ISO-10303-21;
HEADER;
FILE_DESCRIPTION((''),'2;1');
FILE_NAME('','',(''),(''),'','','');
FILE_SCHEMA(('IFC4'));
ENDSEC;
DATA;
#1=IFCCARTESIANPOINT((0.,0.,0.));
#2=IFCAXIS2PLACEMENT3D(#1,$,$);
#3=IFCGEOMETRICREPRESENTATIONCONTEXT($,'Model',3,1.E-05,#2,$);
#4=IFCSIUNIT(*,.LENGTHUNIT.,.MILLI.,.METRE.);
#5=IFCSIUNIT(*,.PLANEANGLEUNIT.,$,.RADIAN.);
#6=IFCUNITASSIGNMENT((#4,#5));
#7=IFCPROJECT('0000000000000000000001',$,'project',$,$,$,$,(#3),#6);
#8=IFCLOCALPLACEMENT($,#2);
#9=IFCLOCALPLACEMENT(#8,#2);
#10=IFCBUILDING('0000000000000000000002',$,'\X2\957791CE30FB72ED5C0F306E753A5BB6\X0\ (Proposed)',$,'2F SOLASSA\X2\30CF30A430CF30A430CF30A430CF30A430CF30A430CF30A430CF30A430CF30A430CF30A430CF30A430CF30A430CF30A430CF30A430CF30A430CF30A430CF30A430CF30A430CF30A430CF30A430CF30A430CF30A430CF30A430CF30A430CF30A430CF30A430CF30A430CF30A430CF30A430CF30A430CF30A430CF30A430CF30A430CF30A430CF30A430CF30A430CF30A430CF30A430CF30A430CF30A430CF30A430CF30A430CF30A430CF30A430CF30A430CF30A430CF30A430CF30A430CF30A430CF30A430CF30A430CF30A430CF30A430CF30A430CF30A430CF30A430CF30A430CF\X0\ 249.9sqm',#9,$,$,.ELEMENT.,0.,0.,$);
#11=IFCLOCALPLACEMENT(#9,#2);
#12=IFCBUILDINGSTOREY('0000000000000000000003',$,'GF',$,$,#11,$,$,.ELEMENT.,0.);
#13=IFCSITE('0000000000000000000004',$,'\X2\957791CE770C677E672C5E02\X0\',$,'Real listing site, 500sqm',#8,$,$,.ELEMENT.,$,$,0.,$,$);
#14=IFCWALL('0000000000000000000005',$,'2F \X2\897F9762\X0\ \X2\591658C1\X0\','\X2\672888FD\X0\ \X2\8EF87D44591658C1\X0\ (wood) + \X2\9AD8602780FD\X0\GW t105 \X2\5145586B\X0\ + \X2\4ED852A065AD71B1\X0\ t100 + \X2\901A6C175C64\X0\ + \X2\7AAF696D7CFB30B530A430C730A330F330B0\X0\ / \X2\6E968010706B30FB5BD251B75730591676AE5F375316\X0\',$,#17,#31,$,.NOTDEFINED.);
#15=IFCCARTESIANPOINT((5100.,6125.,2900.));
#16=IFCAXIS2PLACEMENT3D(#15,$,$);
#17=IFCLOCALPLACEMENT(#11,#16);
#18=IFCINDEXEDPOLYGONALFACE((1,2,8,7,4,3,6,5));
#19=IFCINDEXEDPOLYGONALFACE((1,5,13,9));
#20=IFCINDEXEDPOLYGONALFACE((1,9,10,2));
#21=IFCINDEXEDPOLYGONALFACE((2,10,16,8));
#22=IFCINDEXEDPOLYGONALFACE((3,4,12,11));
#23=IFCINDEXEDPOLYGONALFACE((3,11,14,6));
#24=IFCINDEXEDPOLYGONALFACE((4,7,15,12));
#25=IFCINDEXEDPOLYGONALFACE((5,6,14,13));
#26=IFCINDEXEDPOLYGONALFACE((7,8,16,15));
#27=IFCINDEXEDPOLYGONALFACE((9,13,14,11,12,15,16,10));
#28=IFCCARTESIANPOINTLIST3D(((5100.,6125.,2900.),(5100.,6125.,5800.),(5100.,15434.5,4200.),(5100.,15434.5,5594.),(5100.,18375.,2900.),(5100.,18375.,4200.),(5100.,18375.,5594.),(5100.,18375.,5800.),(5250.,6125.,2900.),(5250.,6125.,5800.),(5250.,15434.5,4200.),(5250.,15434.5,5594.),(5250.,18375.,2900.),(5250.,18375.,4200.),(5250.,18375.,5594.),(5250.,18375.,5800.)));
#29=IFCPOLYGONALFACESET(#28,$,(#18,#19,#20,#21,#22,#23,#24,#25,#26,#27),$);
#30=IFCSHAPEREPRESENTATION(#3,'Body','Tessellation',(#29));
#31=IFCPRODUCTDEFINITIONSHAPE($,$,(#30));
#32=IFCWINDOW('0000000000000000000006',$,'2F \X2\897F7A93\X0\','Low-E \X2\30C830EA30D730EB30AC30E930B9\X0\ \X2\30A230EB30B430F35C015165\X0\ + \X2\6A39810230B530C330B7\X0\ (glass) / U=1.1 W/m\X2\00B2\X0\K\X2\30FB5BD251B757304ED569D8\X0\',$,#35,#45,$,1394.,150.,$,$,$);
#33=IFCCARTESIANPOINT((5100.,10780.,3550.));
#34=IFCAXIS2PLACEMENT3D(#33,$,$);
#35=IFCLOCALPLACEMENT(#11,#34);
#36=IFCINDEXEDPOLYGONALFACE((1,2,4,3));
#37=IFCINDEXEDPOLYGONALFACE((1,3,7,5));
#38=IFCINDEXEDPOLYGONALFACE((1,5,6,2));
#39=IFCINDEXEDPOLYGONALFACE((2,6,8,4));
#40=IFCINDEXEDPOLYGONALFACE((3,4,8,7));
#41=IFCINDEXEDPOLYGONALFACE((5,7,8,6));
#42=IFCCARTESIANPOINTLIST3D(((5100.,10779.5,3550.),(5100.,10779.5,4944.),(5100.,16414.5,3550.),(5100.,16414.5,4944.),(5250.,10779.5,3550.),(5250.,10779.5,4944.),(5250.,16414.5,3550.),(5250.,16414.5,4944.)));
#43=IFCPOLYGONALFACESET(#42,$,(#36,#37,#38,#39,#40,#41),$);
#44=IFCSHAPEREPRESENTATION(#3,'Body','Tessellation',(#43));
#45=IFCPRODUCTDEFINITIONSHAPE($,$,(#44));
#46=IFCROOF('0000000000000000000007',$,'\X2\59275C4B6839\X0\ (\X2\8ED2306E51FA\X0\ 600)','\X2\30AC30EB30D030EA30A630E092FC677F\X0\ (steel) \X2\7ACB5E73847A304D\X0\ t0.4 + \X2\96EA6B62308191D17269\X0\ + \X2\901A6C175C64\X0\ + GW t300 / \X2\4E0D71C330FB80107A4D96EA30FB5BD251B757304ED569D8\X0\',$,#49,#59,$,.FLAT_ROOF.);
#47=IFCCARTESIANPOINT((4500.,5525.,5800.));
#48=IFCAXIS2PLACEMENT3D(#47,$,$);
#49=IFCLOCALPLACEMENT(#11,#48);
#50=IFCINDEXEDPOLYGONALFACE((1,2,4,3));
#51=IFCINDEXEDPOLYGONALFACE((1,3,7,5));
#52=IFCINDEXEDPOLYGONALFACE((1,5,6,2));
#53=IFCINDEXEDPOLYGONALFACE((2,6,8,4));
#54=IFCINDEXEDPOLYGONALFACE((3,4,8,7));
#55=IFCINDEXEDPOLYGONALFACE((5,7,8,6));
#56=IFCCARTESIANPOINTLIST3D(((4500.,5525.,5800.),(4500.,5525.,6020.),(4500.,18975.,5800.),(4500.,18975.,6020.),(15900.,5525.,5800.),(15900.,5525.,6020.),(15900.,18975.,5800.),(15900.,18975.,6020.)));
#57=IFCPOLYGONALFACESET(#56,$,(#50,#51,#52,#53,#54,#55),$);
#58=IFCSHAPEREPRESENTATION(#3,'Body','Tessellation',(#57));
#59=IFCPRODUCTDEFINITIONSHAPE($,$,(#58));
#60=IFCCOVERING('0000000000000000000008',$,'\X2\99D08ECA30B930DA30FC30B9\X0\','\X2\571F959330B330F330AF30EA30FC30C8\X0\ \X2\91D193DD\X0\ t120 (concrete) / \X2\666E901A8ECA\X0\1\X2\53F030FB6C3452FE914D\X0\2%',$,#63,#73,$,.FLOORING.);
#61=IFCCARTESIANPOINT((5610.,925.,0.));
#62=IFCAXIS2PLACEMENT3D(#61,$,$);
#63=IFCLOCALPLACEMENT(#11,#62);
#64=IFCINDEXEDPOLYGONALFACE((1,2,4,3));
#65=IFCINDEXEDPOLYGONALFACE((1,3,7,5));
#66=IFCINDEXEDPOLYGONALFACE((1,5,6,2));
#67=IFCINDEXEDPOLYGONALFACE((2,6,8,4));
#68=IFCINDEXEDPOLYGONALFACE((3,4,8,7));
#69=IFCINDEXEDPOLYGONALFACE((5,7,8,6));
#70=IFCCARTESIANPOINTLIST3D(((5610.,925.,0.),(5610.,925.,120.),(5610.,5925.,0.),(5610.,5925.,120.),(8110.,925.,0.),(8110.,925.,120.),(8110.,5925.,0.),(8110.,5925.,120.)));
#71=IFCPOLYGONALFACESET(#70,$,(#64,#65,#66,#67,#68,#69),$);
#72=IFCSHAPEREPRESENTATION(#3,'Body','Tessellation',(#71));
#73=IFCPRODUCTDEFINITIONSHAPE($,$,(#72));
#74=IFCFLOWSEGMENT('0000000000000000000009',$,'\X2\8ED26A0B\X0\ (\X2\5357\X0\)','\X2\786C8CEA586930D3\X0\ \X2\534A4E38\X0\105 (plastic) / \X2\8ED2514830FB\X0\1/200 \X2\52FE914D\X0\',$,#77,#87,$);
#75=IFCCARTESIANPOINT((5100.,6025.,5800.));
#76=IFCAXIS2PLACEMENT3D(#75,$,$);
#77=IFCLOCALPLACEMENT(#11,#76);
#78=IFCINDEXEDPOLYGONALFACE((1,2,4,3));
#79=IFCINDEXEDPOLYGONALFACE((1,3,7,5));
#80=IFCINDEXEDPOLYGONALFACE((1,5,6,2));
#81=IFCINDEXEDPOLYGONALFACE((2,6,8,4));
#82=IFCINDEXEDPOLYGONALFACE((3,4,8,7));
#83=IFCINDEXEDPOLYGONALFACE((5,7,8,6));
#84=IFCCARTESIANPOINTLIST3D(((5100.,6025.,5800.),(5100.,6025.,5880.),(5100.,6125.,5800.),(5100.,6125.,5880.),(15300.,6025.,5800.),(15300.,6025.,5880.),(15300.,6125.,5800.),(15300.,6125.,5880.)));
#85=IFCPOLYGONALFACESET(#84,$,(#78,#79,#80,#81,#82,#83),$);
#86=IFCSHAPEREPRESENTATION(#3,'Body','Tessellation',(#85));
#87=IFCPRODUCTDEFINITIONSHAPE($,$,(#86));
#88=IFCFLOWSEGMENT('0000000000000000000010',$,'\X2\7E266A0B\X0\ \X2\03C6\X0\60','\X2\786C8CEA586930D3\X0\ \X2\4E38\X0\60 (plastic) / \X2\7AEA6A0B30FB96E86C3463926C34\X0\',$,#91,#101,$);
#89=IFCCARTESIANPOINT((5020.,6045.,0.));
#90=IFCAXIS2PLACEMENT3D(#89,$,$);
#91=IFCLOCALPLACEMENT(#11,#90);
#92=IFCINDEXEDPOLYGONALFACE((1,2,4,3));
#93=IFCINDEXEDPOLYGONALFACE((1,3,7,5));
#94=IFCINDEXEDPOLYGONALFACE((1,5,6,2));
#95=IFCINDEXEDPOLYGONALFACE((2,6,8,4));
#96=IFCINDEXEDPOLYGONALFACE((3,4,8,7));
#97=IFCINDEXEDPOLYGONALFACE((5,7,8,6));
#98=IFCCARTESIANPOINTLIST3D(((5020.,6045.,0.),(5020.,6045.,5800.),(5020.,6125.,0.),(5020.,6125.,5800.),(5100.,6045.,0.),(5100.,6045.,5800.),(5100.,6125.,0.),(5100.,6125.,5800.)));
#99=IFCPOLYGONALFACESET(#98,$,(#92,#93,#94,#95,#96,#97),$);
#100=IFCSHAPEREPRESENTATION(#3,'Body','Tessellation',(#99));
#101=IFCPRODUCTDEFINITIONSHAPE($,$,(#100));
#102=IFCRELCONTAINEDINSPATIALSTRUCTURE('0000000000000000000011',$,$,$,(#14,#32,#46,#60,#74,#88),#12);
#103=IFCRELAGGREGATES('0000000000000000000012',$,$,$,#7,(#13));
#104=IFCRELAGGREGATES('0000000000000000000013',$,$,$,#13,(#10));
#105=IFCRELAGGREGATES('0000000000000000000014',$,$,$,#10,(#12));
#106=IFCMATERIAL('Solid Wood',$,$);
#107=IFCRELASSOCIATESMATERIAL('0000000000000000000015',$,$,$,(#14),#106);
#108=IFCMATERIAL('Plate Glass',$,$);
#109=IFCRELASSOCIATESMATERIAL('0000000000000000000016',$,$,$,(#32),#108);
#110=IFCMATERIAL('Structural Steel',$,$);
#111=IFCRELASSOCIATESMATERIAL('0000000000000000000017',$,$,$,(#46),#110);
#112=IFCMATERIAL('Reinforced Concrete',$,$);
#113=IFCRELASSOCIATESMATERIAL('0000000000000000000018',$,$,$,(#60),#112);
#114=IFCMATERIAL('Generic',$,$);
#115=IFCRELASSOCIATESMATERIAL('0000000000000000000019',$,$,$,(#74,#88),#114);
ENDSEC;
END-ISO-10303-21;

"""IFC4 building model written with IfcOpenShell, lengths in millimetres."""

from ifc_helpers import new_model, si_unit, frame, frame_2d, origin, place, context, project, spatial, rectangle, extrude, material, element, fill, save


model = new_model("IFC4")

# Units and contexts
model_context = context("Model", 3, precision=1e-05, world=origin())
ifc_project = project(units=[si_unit("LENGTHUNIT", "METRE", prefix="MILLI"), si_unit("PLANEANGLEUNIT", "RADIAN")], contexts=[model_context])

# Site, building, storey
site_placement = place(None, origin())
site = spatial("IfcSite", under=ifc_project, at=site_placement, Name="長野県松本市", ObjectType="Real listing site, 500sqm", CompositionType="ELEMENT", RefElevation=0.0)
building_placement = place(site_placement, origin())
building = spatial("IfcBuilding", under=site, at=building_placement, Name="長野・狭小の町家 (Proposed)", ObjectType="2F SOLASSAハイハイハイハイハイハイハイハイハイハイハイハイハイハイハイハイハイハイハイハイハイハイハイハイハイハイハイハイハイハイハイハイハイハイハイハイハイハイハイハイハイハイハイハイハイハイハイハイハイハイハイハイハイハイハイハイハ 249.9sqm", CompositionType="ELEMENT", ElevationOfRefHeight=0.0, ElevationOfTerrain=0.0)
storey_placement = place(building_placement, origin())
storey = spatial("IfcBuildingStorey", under=building, at=storey_placement, Name="GF", CompositionType="ELEMENT", Elevation=0.0)

# Shared definitions
ifc_material_1 = material(Name="Solid Wood")

# Shared definitions
ifc_material_2 = material(Name="Reinforced Concrete")

# Shared definitions
ifc_material_3 = material(Name="Plate Glass")

# Wall, opening, window
wall_1_placement = place(storey_placement, frame((5100.0, 6125.0, 2900.0)))
wall_1 = element("IfcWall", 1, at=wall_1_placement, inside=storey, material=ifc_material_1, Name="2F 西面 外壁", Description="木製 軸組外壁 (wood) + 高性能GW t105 充填 + 付加断熱 t100 + 通気層 + 窯業系サイディング / 準耐火・寒冷地外皮強化", PredefinedType="NOTDEFINED", context=model_context, shape_type="SweptSolid", body=[
    extrude(rectangle(XDim=150.0, YDim=12250.0, at=frame_2d((75.0, 6125.0))), frame((5100.0, 6125.0, 2900.0)), (0.0, 0.0, 1.0), 2900.0),
])
opening_1_placement = place(storey_placement, frame((5100.0, 10780.0, 3550.0)))
opening_1 = element("IfcOpeningElement", 2, at=opening_1_placement, cuts=wall_1, PredefinedType="NOTDEFINED", context=model_context, shape_type="SweptSolid", body=[
    extrude(rectangle(XDim=150.0, YDim=5635.0, at=frame_2d((75.0, 2817.0))), frame((5100.0, 10780.0, 3550.0)), (0.0, 0.0, 1.0), 1394.0),
])
window_1_placement = place(storey_placement, frame((5100.0, 10780.0, 3550.0)))
window_1 = element("IfcWindow", 3, at=window_1_placement, inside=storey, material=ifc_material_3, Name="2F 西窓", Description="Low-E トリプルガラス アルゴン封入 + 樹脂サッシ (glass) / U=1.1 W/m²K・寒冷地仕様", OverallHeight=1394.0, OverallWidth=150.0, context=model_context, shape_type="SweptSolid", body=[
    extrude(rectangle(XDim=150.0, YDim=5635.0, at=frame_2d((75.0, 2817.0))), frame((5100.0, 10780.0, 3550.0)), (0.0, 0.0, 1.0), 1394.0),
])
fill(opening_1, window_1)

# Roof
ifc_material_4 = material(Name="Structural Steel")
roof_placement = place(storey_placement, frame((4500.0, 5525.0, 5800.0)))
element("IfcRoof", 4, at=roof_placement, inside=storey, material=ifc_material_4, Name="大屋根 (軒の出 600)", Description="ガルバリウム鋼板 (steel) 立平葺き t0.4 + 雪止め金物 + 通気層 + GW t300 / 不燃・耐積雪・寒冷地仕様", PredefinedType="FLAT_ROOF", context=model_context, shape_type="SweptSolid", body=[
    extrude(rectangle(XDim=11400.0, YDim=13450.0, at=frame_2d((5700.0, 6725.0))), frame((4500.0, 5525.0, 5800.0)), (0.0, 0.0, 1.0), 220.0),
])

# Covering
covering_placement = place(storey_placement, frame((5610.0, 925.0, 0.0)))
element("IfcCovering", 5, at=covering_placement, inside=storey, material=ifc_material_2, Name="駐車スペース", Description="土間コンクリート 金鏝 t120 (concrete) / 普通車1台・水勾配2%", PredefinedType="FLOORING", context=model_context, shape_type="SweptSolid", body=[
    extrude(rectangle(XDim=2500.0, YDim=5000.0, at=frame_2d((1250.0, 2500.0))), frame((5610.0, 925.0, 0.0)), (0.0, 0.0, 1.0), 120.0),
])

# Flow segments
ifc_material_5 = material(Name="Generic")
flow_segment_1_placement = place(storey_placement, frame((5100.0, 6025.0, 5800.0)))
element("IfcFlowSegment", 6, at=flow_segment_1_placement, inside=storey, material=ifc_material_5, Name="軒樋 (南)", Description="硬質塩ビ 半丸105 (plastic) / 軒先・1/200 勾配", context=model_context, shape_type="SweptSolid", body=[
    extrude(rectangle(XDim=10200.0, YDim=100.0, at=frame_2d((5100.0, 50.0))), frame((5100.0, 6025.0, 5800.0)), (0.0, 0.0, 1.0), 80.0),
])
flow_segment_2_placement = place(storey_placement, frame((5020.0, 6045.0, 0.0)))
element("IfcFlowSegment", 7, at=flow_segment_2_placement, inside=storey, material=ifc_material_5, Name="縦樋 φ60", Description="硬質塩ビ 丸60 (plastic) / 竪樋・雨水排水", context=model_context, shape_type="SweptSolid", body=[
    extrude(rectangle(XDim=80.0, YDim=80.0, at=frame_2d((40.0, 40.0))), frame((5020.0, 6045.0, 0.0)), (0.0, 0.0, 1.0), 5800.0),
])

save(model, "model.ifc")
